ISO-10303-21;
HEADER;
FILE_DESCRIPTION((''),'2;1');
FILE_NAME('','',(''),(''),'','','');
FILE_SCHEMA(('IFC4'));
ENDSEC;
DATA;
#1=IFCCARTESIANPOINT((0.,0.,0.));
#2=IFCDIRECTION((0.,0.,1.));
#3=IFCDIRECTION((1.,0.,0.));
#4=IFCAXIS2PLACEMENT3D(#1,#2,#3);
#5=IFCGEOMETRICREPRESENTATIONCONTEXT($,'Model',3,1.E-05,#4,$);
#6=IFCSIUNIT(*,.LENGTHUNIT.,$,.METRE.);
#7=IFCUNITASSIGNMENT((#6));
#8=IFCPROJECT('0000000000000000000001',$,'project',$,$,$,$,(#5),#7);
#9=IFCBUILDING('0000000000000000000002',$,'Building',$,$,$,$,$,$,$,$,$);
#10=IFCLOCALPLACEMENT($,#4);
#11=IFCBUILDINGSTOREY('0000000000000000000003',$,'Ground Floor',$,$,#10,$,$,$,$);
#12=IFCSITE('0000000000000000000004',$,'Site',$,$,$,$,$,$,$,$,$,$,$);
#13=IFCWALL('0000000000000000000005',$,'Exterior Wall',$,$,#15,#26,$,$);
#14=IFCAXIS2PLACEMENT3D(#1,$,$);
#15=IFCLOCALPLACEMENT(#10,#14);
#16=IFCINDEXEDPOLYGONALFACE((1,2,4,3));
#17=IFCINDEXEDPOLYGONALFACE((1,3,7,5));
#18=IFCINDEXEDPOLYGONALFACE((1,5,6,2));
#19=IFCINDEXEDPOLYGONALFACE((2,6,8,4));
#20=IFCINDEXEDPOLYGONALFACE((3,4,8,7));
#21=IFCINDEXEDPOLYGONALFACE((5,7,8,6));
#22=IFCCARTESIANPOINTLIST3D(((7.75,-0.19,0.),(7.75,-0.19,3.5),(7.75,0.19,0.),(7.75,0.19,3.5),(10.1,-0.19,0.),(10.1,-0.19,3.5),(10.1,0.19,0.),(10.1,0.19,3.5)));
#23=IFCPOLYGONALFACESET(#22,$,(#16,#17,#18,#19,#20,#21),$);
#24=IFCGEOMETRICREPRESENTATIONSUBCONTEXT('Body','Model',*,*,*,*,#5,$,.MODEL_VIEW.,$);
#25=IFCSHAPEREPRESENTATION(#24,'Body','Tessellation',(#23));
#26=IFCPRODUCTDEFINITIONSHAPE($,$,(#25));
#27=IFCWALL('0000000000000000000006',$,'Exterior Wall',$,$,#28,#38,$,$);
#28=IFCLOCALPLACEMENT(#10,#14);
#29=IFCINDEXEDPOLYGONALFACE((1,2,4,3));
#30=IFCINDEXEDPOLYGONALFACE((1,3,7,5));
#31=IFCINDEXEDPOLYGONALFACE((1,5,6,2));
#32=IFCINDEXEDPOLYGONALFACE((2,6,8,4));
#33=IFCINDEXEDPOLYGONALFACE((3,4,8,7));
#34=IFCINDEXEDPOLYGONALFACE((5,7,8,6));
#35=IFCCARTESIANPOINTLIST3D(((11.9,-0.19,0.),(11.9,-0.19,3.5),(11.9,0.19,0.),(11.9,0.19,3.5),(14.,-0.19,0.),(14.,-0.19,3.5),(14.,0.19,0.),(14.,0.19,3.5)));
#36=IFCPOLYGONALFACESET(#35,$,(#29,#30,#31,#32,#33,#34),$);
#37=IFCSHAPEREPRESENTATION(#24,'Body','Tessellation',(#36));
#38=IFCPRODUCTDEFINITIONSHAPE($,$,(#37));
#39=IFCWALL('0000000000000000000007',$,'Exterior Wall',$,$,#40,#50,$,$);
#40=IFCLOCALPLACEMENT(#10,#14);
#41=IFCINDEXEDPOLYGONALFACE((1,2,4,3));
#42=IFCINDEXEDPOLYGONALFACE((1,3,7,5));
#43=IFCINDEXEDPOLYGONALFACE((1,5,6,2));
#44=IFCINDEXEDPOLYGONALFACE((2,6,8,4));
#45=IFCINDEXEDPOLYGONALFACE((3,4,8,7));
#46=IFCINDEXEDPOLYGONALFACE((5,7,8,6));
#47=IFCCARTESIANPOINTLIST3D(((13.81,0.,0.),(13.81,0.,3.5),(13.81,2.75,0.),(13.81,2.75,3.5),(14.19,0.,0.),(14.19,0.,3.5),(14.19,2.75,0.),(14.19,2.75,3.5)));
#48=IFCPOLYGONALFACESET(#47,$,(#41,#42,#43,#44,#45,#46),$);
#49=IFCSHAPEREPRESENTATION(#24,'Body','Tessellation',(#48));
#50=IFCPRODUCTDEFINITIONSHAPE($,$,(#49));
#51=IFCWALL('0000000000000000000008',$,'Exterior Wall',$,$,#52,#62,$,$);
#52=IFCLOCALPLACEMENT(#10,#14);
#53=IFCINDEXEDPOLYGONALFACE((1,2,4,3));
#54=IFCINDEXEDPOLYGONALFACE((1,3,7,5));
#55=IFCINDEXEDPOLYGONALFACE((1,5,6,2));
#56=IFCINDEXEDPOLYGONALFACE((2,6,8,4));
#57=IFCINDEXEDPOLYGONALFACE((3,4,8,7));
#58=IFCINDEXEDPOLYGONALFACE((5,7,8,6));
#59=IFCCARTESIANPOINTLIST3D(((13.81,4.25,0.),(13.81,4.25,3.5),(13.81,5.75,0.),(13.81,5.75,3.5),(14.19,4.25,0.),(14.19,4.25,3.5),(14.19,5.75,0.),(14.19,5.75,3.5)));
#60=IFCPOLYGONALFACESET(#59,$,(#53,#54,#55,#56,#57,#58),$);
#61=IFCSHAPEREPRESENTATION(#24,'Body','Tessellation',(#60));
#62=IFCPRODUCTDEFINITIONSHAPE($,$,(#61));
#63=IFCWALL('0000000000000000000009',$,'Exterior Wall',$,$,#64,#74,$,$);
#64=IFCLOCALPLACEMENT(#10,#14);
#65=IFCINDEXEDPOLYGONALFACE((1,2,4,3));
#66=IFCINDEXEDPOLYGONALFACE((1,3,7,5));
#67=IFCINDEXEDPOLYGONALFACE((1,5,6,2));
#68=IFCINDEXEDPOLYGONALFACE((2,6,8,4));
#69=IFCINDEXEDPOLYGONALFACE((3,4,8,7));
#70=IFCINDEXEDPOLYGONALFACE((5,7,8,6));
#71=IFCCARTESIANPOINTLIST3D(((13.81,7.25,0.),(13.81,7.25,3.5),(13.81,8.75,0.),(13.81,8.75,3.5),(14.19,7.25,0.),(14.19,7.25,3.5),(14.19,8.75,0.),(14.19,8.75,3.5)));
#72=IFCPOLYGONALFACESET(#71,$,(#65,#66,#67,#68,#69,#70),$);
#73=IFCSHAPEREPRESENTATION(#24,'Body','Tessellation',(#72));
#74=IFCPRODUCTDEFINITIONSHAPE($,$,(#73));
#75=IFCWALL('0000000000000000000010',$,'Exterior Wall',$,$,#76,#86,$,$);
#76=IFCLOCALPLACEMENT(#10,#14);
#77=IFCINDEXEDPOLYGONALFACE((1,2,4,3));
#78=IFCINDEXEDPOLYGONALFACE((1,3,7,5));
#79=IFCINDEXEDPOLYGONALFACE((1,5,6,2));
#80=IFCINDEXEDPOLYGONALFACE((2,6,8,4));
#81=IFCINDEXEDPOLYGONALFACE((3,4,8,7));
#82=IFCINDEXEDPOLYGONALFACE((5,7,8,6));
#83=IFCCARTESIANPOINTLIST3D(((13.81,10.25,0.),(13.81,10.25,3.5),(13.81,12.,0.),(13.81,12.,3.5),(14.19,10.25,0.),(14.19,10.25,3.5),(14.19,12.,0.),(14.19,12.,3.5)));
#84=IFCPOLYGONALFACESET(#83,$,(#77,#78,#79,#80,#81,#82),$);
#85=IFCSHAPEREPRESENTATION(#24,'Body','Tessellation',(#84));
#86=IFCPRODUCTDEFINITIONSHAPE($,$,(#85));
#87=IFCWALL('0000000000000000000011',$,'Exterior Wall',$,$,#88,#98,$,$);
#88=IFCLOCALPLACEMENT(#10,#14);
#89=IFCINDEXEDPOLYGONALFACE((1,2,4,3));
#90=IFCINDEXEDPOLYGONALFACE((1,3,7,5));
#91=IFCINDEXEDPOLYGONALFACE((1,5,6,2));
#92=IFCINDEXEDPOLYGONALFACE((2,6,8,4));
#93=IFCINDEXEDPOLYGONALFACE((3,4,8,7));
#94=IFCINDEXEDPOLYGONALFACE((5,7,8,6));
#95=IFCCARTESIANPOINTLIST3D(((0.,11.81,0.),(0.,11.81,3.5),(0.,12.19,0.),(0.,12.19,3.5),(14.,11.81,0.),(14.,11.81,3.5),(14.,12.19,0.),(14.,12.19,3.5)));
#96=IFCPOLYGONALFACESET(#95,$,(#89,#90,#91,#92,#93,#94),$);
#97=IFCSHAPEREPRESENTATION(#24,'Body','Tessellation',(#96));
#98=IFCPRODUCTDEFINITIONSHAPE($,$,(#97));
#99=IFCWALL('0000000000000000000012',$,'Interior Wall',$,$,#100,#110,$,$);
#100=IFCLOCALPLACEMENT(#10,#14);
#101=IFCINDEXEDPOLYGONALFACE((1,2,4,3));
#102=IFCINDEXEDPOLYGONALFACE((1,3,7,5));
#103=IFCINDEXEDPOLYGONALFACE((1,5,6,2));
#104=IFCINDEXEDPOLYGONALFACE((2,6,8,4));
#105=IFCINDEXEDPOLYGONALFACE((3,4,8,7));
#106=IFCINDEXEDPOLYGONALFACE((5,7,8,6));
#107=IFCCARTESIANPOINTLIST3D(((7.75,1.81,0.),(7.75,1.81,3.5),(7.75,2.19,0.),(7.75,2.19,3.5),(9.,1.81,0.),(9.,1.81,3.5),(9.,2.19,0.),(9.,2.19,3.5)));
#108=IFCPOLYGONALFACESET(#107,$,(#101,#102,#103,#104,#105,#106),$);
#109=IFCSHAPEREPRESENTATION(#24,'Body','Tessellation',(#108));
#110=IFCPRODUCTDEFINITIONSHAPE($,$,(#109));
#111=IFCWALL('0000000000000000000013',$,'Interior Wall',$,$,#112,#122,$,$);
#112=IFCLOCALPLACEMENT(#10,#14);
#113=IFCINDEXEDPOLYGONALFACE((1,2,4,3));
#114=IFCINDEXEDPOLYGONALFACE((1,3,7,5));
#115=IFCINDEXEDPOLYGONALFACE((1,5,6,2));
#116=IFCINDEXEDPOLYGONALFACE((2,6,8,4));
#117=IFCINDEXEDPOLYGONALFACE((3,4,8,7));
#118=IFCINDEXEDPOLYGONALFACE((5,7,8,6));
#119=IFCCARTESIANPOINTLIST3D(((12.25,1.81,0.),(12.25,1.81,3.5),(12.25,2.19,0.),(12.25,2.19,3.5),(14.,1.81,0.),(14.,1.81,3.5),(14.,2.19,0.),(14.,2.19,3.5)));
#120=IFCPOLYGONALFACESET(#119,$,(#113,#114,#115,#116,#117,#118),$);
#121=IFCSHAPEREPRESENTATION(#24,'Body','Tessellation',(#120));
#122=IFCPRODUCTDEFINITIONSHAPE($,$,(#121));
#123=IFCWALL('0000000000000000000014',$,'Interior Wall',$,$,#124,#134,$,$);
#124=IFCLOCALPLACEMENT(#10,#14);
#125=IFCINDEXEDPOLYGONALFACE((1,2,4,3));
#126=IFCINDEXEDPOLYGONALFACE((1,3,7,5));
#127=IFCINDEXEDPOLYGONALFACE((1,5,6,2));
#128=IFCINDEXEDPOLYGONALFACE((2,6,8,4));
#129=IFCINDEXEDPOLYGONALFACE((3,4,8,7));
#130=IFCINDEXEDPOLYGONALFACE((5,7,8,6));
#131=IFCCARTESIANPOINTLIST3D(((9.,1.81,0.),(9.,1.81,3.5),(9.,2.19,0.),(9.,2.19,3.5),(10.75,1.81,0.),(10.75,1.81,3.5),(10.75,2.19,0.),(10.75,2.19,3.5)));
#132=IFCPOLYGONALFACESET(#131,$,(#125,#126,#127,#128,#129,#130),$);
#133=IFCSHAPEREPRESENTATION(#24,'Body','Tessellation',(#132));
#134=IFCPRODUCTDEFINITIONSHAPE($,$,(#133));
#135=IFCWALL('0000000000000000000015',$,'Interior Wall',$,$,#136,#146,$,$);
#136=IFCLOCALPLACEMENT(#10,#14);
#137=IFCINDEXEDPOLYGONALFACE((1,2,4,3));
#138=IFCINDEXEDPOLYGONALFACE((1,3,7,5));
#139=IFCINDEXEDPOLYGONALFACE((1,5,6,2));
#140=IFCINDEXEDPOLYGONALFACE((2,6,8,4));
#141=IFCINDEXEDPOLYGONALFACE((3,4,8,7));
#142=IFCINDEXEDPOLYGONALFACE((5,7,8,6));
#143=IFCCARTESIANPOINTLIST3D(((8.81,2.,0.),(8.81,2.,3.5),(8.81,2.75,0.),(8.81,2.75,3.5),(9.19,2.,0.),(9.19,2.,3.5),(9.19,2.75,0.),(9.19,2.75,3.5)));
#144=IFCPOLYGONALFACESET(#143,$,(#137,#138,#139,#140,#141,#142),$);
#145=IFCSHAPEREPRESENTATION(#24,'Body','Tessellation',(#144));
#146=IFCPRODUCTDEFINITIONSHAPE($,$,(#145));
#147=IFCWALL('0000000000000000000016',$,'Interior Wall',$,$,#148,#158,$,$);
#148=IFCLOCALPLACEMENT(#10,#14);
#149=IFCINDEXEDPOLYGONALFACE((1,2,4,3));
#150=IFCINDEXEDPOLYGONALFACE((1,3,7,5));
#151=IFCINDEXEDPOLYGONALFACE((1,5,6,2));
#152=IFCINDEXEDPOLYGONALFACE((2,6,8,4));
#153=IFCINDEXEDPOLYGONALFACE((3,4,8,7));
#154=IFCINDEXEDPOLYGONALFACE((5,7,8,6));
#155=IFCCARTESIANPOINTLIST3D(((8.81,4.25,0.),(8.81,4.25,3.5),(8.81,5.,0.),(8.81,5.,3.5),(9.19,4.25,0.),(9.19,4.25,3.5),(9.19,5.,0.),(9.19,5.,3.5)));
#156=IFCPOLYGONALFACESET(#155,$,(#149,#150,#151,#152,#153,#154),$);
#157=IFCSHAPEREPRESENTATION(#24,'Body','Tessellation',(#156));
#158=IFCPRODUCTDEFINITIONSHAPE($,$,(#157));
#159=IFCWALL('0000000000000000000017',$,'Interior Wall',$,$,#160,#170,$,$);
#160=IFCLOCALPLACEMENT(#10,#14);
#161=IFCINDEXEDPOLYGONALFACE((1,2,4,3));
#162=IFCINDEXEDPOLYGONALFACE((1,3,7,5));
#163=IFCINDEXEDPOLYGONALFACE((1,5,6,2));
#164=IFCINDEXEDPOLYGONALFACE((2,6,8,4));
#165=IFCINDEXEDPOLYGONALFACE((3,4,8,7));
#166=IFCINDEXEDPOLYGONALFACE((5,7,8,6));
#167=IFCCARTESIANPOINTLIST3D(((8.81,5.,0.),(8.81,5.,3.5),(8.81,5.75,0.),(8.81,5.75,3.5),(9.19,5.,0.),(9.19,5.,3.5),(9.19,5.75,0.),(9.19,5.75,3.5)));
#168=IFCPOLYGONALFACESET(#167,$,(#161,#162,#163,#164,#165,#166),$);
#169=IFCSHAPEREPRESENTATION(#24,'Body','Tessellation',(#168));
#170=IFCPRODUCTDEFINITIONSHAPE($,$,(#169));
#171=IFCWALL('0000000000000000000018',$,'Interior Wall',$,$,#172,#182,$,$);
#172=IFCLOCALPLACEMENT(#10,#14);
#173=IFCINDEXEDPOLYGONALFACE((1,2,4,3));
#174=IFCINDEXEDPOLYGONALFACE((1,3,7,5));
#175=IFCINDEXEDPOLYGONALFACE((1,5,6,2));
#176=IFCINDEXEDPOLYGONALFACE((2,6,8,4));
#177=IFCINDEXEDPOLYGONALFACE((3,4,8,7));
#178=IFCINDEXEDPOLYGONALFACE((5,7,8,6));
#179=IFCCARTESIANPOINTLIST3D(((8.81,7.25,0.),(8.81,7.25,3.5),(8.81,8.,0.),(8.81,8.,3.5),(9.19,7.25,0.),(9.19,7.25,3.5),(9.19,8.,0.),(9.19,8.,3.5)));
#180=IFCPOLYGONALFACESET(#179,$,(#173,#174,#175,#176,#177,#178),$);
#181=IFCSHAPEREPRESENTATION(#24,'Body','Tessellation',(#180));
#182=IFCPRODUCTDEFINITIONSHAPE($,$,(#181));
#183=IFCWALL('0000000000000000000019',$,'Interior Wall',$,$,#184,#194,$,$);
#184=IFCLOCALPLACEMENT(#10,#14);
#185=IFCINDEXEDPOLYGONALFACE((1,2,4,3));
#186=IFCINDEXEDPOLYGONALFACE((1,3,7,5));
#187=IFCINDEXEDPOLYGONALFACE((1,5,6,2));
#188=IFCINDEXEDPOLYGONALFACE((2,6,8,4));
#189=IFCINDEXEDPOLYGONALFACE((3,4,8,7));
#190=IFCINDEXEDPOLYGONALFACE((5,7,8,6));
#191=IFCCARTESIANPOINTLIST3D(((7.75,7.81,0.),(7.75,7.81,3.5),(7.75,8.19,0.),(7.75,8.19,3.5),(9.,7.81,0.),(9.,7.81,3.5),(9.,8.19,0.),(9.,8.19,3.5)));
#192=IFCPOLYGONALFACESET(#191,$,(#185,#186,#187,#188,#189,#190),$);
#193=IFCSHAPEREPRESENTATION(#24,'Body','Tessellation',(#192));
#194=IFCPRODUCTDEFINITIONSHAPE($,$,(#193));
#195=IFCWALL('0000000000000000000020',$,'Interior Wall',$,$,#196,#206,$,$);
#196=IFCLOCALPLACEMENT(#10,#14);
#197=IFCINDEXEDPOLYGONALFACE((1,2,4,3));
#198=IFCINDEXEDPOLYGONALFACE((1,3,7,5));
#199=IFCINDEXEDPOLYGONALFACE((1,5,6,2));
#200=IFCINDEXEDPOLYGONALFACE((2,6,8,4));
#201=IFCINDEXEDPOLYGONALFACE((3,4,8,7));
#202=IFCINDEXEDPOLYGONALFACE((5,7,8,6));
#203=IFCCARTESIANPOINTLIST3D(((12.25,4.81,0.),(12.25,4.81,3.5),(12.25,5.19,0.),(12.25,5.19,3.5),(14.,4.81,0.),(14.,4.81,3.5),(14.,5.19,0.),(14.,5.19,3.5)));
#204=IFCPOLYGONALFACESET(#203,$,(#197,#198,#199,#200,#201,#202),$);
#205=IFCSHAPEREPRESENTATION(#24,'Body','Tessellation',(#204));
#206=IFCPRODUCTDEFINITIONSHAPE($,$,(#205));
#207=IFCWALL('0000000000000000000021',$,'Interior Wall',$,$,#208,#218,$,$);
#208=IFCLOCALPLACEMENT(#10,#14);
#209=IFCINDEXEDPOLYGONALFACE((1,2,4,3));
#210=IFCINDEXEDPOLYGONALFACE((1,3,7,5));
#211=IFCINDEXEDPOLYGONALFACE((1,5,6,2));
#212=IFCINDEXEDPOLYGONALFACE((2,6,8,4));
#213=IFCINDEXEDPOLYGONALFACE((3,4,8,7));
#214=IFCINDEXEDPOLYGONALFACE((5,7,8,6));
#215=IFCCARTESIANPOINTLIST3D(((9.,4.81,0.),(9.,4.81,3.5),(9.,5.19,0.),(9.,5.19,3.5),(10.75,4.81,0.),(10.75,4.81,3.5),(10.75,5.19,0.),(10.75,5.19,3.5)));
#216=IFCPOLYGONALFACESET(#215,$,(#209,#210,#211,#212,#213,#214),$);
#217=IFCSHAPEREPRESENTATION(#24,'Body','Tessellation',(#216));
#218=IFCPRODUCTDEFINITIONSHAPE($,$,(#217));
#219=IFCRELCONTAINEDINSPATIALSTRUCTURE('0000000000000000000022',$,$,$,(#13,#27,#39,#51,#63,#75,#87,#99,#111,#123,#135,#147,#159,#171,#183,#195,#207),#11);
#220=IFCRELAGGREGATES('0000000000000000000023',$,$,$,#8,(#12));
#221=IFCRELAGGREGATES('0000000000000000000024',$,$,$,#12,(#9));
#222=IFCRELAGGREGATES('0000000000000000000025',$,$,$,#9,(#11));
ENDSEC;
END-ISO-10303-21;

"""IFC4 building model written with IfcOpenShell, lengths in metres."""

from ifc_helpers import new_model, si_unit, frame, origin_with_axes, place, context, subcontext, project, spatial, indexed_curve, outline, extrude, element, save


model = new_model("IFC4")

# Units and contexts
model_context = context("Model", 3, precision=1e-05, world=origin_with_axes())
body_context = subcontext(model_context, "Body", "Model", "MODEL_VIEW")
ifc_project = project(units=[si_unit("LENGTHUNIT", "METRE")], contexts=[model_context])

# Site, building, storey
site = spatial("IfcSite", under=ifc_project, Name="Site")
building = spatial("IfcBuilding", under=site, Name="Building")
storey_placement = place(None, origin_with_axes())
storey = spatial("IfcBuildingStorey", under=building, at=storey_placement, Name="Ground Floor")

# Walls
wall_1_placement = place(storey_placement, frame((7.75, 0.0, 0.0), z_axis=(0.0, 0.0, 1.0), x_axis=(1.0, 0.0, 0.0)))
element("IfcWall", 1, at=wall_1_placement, inside=storey, Name="Exterior Wall", context=body_context, shape_type="SweptSolid", body=[
    extrude(outline(indexed_curve([(0.0, 0.0), (0.0, 0.38), (2.35, 0.38), (2.35, 0.0), (0.0, 0.0)], self_intersect=False)), frame((0.0, -0.19, 0.0), z_axis=(0.0, 0.0, 1.0), x_axis=(1.0, 0.0, 0.0)), (0.0, 0.0, 1.0), 3.5),
])
wall_2_placement = place(storey_placement, frame((11.9, 0.0, 0.0), z_axis=(0.0, 0.0, 1.0), x_axis=(1.0, 0.0, 0.0)))
element("IfcWall", 2, at=wall_2_placement, inside=storey, Name="Exterior Wall", context=body_context, shape_type="SweptSolid", body=[
    extrude(outline(indexed_curve([(0.0, 0.0), (0.0, 0.38), (2.1, 0.38), (2.1, 0.0), (0.0, 0.0)], self_intersect=False)), frame((0.0, -0.19, 0.0), z_axis=(0.0, 0.0, 1.0), x_axis=(1.0, 0.0, 0.0)), (0.0, 0.0, 1.0), 3.5),
])
wall_3_placement = place(storey_placement, frame((14.0, 0.0, 0.0), z_axis=(0.0, 0.0, 1.0), x_axis=(0.0, 1.0, 0.0)))
element("IfcWall", 3, at=wall_3_placement, inside=storey, Name="Exterior Wall", context=body_context, shape_type="SweptSolid", body=[
    extrude(outline(indexed_curve([(0.0, 0.0), (0.0, 0.38), (2.75, 0.38), (2.75, 0.0), (0.0, 0.0)], self_intersect=False)), frame((0.0, -0.19, 0.0), z_axis=(0.0, 0.0, 1.0), x_axis=(1.0, 0.0, 0.0)), (0.0, 0.0, 1.0), 3.5),
])
for number, where, z_axis, x_axis, name in (
    (4, (14.0, 4.25, 0.0), (0.0, 0.0, 1.0), (0.0, 1.0, 0.0), "Exterior Wall"),
    (5, (14.0, 7.25, 0.0), (0.0, 0.0, 1.0), (0.0, 1.0, 0.0), "Exterior Wall"),
):
    element("IfcWall", number, at=place(storey_placement, frame(where, z_axis=z_axis, x_axis=x_axis)), inside=storey, Name=name, context=body_context, shape_type="SweptSolid", body=[
        extrude(outline(indexed_curve([(0.0, 0.0), (0.0, 0.38), (1.5, 0.38), (1.5, 0.0), (0.0, 0.0)], self_intersect=False)), frame((0.0, -0.19, 0.0), z_axis=(0.0, 0.0, 1.0), x_axis=(1.0, 0.0, 0.0)), (0.0, 0.0, 1.0), 3.5),
    ])
wall_4_placement = place(storey_placement, frame((14.0, 10.25, 0.0), z_axis=(0.0, 0.0, 1.0), x_axis=(0.0, 1.0, 0.0)))
element("IfcWall", 6, at=wall_4_placement, inside=storey, Name="Exterior Wall", context=body_context, shape_type="SweptSolid", body=[
    extrude(outline(indexed_curve([(0.0, 0.0), (0.0, 0.38), (1.75, 0.38), (1.75, 0.0), (0.0, 0.0)], self_intersect=False)), frame((0.0, -0.19, 0.0), z_axis=(0.0, 0.0, 1.0), x_axis=(1.0, 0.0, 0.0)), (0.0, 0.0, 1.0), 3.5),
])
wall_5_placement = place(storey_placement, frame((14.0, 12.0, 0.0), z_axis=(0.0, 0.0, 1.0), x_axis=(-1.0, 0.0, 0.0)))
element("IfcWall", 7, at=wall_5_placement, inside=storey, Name="Exterior Wall", context=body_context, shape_type="SweptSolid", body=[
    extrude(outline(indexed_curve([(0.0, 0.0), (0.0, 0.38), (14.0, 0.38), (14.0, 0.0), (0.0, 0.0)], self_intersect=False)), frame((0.0, -0.19, 0.0), z_axis=(0.0, 0.0, 1.0), x_axis=(1.0, 0.0, 0.0)), (0.0, 0.0, 1.0), 3.5),
])
wall_6_placement = place(storey_placement, frame((9.0, 2.0, 0.0), z_axis=(0.0, 0.0, 1.0), x_axis=(-1.0, 0.0, 0.0)))
element("IfcWall", 8, at=wall_6_placement, inside=storey, Name="Interior Wall", context=body_context, shape_type="SweptSolid", body=[
    extrude(outline(indexed_curve([(0.0, 0.0), (0.0, 0.38), (1.25, 0.38), (1.25, 0.0), (0.0, 0.0)], self_intersect=False)), frame((0.0, -0.19, 0.0), z_axis=(0.0, 0.0, 1.0), x_axis=(1.0, 0.0, 0.0)), (0.0, 0.0, 1.0), 3.5),
])
for number, where, z_axis, x_axis, name in (
    (9, (14.0, 2.0, 0.0), (0.0, 0.0, 1.0), (-1.0, 0.0, 0.0), "Interior Wall"),
    (10, (10.75, 2.0, 0.0), (0.0, 0.0, 1.0), (-1.0, 0.0, 0.0), "Interior Wall"),
):
    element("IfcWall", number, at=place(storey_placement, frame(where, z_axis=z_axis, x_axis=x_axis)), inside=storey, Name=name, context=body_context, shape_type="SweptSolid", body=[
        extrude(outline(indexed_curve([(0.0, 0.0), (0.0, 0.38), (1.75, 0.38), (1.75, 0.0), (0.0, 0.0)], self_intersect=False)), frame((0.0, -0.19, 0.0), z_axis=(0.0, 0.0, 1.0), x_axis=(1.0, 0.0, 0.0)), (0.0, 0.0, 1.0), 3.5),
    ])
for number, where, z_axis, x_axis, name in (
    (11, (9.0, 2.0, 0.0), (0.0, 0.0, 1.0), (0.0, 1.0, 0.0), "Interior Wall"),
    (12, (9.0, 4.25, 0.0), (0.0, 0.0, 1.0), (0.0, 1.0, 0.0), "Interior Wall"),
    (13, (9.0, 5.0, 0.0), (0.0, 0.0, 1.0), (0.0, 1.0, 0.0), "Interior Wall"),
    (14, (9.0, 7.25, 0.0), (0.0, 0.0, 1.0), (0.0, 1.0, 0.0), "Interior Wall"),
):
    element("IfcWall", number, at=place(storey_placement, frame(where, z_axis=z_axis, x_axis=x_axis)), inside=storey, Name=name, context=body_context, shape_type="SweptSolid", body=[
        extrude(outline(indexed_curve([(0.0, 0.0), (0.0, 0.38), (0.75, 0.38), (0.75, 0.0), (0.0, 0.0)], self_intersect=False)), frame((0.0, -0.19, 0.0), z_axis=(0.0, 0.0, 1.0), x_axis=(1.0, 0.0, 0.0)), (0.0, 0.0, 1.0), 3.5),
    ])
wall_7_placement = place(storey_placement, frame((9.0, 8.0, 0.0), z_axis=(0.0, 0.0, 1.0), x_axis=(-1.0, 0.0, 0.0)))
element("IfcWall", 15, at=wall_7_placement, inside=storey, Name="Interior Wall", context=body_context, shape_type="SweptSolid", body=[
    extrude(outline(indexed_curve([(0.0, 0.0), (0.0, 0.38), (1.25, 0.38), (1.25, 0.0), (0.0, 0.0)], self_intersect=False)), frame((0.0, -0.19, 0.0), z_axis=(0.0, 0.0, 1.0), x_axis=(1.0, 0.0, 0.0)), (0.0, 0.0, 1.0), 3.5),
])
for number, where, z_axis, x_axis, name in (
    (16, (14.0, 5.0, 0.0), (0.0, 0.0, 1.0), (-1.0, 0.0, 0.0), "Interior Wall"),
    (17, (10.75, 5.0, 0.0), (0.0, 0.0, 1.0), (-1.0, 0.0, 0.0), "Interior Wall"),
):
    element("IfcWall", number, at=place(storey_placement, frame(where, z_axis=z_axis, x_axis=x_axis)), inside=storey, Name=name, context=body_context, shape_type="SweptSolid", body=[
        extrude(outline(indexed_curve([(0.0, 0.0), (0.0, 0.38), (1.75, 0.38), (1.75, 0.0), (0.0, 0.0)], self_intersect=False)), frame((0.0, -0.19, 0.0), z_axis=(0.0, 0.0, 1.0), x_axis=(1.0, 0.0, 0.0)), (0.0, 0.0, 1.0), 3.5),
    ])

save(model, "model.ifc")
